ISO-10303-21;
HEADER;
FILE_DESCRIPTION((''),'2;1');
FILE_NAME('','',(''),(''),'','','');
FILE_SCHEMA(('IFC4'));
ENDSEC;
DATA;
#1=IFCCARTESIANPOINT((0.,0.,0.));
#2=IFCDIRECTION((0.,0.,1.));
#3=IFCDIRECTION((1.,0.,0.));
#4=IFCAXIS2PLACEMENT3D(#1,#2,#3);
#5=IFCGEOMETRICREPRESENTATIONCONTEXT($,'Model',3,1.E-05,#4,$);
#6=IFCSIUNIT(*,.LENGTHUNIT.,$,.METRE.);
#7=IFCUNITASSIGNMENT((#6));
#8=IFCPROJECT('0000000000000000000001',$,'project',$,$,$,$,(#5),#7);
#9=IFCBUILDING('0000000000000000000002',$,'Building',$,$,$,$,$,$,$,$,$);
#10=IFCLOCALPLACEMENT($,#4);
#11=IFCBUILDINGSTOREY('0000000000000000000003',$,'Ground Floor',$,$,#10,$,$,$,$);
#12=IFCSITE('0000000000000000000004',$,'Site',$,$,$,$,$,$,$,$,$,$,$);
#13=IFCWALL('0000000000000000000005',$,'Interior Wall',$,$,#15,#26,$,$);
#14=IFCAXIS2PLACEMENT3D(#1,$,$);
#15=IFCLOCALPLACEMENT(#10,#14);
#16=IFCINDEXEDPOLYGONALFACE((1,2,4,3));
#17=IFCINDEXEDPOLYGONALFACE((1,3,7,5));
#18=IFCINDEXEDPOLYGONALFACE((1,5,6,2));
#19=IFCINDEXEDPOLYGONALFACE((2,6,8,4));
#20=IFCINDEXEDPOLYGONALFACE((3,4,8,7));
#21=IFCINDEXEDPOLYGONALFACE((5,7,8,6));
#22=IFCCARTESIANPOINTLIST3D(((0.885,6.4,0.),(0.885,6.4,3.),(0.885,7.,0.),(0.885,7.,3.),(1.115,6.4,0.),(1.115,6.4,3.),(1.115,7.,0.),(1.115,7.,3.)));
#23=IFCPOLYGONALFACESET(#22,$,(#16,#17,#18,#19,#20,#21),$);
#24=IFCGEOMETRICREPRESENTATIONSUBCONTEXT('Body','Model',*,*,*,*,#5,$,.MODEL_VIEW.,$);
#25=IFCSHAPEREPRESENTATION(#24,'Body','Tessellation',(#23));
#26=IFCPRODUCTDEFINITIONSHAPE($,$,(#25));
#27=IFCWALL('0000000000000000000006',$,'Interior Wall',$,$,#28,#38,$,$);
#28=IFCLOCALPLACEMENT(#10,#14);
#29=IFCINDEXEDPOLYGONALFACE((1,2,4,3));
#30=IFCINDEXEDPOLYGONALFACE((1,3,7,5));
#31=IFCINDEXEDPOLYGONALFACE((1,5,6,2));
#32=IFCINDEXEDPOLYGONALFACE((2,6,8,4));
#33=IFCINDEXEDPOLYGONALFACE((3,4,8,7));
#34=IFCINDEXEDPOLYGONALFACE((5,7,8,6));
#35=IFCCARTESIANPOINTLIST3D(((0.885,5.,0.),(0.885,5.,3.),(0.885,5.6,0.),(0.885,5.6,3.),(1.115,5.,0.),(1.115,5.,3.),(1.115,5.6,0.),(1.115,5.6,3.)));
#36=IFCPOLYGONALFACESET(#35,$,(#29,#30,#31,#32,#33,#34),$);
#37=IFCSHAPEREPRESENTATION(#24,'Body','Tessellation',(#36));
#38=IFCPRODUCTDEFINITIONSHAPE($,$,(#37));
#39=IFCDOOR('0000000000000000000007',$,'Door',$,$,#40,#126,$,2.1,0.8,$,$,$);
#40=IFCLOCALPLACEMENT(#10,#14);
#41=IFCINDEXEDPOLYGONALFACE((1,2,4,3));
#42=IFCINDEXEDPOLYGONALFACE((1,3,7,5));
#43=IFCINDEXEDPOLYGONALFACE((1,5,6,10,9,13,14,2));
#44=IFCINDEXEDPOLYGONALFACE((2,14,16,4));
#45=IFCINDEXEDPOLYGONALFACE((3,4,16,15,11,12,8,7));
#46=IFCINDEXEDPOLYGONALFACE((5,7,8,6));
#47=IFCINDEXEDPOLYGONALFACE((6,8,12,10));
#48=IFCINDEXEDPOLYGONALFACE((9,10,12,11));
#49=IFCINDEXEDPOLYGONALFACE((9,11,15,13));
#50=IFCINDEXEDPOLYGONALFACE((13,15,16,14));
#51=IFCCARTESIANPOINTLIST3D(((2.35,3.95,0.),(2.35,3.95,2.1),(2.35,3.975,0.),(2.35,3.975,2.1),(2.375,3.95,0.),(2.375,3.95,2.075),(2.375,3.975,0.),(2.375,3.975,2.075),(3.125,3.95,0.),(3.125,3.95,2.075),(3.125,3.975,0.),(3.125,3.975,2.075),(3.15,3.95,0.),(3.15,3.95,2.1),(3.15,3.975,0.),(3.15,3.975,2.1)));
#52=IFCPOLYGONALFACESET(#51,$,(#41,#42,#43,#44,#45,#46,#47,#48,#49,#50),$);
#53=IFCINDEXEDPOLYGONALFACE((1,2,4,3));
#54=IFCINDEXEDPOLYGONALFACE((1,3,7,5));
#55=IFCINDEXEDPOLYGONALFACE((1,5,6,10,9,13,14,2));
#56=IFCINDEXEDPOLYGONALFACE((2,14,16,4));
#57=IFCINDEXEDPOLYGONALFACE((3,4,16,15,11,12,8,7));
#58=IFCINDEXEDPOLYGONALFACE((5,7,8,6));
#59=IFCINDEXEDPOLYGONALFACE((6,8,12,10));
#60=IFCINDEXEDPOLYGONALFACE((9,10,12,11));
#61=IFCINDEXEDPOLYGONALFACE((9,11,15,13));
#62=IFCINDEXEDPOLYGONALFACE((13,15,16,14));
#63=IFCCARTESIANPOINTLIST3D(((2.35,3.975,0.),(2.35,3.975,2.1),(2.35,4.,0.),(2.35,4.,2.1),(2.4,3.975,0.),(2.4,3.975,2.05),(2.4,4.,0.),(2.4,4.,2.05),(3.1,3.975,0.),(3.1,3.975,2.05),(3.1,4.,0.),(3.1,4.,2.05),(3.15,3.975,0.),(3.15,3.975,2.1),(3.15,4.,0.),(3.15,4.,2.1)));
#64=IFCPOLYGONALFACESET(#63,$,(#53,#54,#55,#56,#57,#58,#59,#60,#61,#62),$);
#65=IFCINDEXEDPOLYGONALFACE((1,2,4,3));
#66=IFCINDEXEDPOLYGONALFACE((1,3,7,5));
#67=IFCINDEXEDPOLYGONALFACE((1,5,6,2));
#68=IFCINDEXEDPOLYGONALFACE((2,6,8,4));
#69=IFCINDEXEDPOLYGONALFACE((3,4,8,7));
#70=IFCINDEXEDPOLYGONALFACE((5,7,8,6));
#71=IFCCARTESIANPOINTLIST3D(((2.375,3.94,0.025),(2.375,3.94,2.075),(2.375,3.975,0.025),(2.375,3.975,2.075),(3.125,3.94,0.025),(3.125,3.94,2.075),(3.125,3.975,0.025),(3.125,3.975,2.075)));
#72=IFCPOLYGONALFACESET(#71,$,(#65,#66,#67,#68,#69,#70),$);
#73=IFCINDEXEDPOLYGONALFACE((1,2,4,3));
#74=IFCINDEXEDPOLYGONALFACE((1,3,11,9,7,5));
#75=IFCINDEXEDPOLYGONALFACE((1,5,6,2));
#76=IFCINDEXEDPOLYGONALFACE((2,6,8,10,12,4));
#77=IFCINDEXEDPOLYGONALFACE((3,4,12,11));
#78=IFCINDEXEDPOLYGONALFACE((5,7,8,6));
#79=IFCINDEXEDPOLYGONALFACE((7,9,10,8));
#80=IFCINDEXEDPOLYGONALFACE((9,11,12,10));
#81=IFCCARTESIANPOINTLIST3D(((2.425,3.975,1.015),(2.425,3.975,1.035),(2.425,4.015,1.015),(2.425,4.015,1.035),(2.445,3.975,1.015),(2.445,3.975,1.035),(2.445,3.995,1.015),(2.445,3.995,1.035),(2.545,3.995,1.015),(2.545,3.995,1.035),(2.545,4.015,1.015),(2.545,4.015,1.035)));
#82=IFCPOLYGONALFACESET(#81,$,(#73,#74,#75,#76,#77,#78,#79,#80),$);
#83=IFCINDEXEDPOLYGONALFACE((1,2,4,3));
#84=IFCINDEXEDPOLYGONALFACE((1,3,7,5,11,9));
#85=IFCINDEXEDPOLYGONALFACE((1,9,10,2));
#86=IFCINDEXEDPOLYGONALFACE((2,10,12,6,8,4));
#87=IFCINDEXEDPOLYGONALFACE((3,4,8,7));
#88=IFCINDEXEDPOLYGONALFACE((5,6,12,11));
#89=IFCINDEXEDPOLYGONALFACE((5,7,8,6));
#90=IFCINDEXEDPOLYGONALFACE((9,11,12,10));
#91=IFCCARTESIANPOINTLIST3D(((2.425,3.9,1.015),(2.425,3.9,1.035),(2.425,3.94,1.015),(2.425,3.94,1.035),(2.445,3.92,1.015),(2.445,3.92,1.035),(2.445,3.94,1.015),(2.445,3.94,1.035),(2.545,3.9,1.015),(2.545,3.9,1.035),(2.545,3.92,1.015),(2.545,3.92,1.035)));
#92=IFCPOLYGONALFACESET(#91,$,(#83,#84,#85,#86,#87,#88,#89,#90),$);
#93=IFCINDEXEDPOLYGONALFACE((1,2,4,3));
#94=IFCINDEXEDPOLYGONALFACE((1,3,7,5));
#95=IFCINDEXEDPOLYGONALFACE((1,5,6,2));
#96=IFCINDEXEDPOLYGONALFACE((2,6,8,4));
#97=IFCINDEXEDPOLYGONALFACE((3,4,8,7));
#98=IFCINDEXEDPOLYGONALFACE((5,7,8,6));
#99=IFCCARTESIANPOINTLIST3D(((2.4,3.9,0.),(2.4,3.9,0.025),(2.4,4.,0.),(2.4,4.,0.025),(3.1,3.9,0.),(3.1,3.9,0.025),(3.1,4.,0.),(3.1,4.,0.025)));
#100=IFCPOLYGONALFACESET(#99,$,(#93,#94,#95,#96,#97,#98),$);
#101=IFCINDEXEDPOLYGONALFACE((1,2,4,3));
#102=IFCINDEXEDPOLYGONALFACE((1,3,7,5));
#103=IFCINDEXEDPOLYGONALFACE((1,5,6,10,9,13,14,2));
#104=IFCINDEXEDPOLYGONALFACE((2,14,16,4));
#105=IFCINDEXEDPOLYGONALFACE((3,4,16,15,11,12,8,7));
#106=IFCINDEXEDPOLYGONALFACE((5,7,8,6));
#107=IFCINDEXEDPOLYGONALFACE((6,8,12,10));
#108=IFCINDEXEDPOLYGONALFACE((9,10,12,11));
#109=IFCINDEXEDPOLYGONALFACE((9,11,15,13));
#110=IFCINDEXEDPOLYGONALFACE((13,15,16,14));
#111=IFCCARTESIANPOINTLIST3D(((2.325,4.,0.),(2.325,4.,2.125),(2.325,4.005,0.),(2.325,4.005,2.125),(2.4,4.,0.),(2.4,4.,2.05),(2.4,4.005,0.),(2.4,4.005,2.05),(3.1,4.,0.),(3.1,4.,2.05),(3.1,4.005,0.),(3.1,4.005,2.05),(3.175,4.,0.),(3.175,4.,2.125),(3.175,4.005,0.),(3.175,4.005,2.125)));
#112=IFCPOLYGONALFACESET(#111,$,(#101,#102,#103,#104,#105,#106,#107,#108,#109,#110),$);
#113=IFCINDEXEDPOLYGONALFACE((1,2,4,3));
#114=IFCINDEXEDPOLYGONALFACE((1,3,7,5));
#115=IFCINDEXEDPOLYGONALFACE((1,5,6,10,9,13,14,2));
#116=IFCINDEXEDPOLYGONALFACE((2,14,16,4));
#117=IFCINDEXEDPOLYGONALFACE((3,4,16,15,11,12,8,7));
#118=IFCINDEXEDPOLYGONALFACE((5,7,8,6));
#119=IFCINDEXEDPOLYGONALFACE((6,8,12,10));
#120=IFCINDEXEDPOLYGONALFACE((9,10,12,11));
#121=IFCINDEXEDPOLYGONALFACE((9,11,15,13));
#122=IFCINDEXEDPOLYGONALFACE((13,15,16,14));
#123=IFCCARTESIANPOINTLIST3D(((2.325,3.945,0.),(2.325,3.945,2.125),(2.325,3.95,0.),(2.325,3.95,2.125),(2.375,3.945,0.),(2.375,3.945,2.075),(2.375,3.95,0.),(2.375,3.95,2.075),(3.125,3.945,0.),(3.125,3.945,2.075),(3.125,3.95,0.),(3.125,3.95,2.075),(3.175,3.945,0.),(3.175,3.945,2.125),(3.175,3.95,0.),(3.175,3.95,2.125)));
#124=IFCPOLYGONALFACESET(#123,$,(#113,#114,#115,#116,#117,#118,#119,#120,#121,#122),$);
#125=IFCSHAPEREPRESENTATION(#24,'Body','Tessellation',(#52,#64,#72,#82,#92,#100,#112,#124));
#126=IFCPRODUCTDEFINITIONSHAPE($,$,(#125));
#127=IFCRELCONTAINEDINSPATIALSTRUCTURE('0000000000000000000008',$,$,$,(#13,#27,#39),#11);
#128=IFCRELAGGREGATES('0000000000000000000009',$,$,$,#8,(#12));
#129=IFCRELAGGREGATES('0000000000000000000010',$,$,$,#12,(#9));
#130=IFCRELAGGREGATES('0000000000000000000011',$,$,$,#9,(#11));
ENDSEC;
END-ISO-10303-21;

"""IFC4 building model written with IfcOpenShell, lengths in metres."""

from ifc_helpers import new_model, si_unit, frame, origin_with_axes, place, context, subcontext, project, spatial, line, indexed_curve, outline, extrude, element, save


model = new_model("IFC4")

# Units and contexts
model_context = context("Model", 3, precision=1e-05, world=origin_with_axes())
body_context = subcontext(model_context, "Body", "Model", "MODEL_VIEW")
ifc_project = project(units=[si_unit("LENGTHUNIT", "METRE")], contexts=[model_context])

# Site, building, storey
site = spatial("IfcSite", under=ifc_project, Name="Site")
building = spatial("IfcBuilding", under=site, Name="Building")
storey_placement = place(None, origin_with_axes())
storey = spatial("IfcBuildingStorey", under=building, at=storey_placement, Name="Ground Floor")

# Walls
for number, where, z_axis, x_axis, name in (
    (1, (1.0, 7.0, 0.0), (0.0, 0.0, 1.0), (0.0, -1.0, 0.0), "Interior Wall"),
    (2, (1.0, 5.6, 0.0), (0.0, 0.0, 1.0), (0.0, -1.0, 0.0), "Interior Wall"),
):
    element("IfcWall", number, at=place(storey_placement, frame(where, z_axis=z_axis, x_axis=x_axis)), inside=storey, Name=name, context=body_context, shape_type="SweptSolid", body=[
        extrude(outline(indexed_curve([(0.0, 0.0), (0.0, 0.23), (0.6, 0.23), (0.6, 0.0), (0.0, 0.0)], self_intersect=False)), frame((0.0, -0.115, 0.0), z_axis=(0.0, 0.0, 1.0), x_axis=(1.0, 0.0, 0.0)), (0.0, 0.0, 1.0), 3.0),
    ])

# Door
door_1_placement = place(storey_placement, frame((3.15, 4.0, 0.0), z_axis=(0.0, 0.0, 1.0), x_axis=(-1.0, 0.0, 0.0)))
element("IfcDoor", 3, at=door_1_placement, inside=storey, Name="Door", OverallHeight=2.1, OverallWidth=0.8, context=body_context, shape_type="SweptSolid", body=[
    extrude(outline(indexed_curve([(0.0, 0.0), (0.0, 2.1), (0.8, 2.1), (0.8, 0.0), (0.775, 0.0), (0.775, 2.075), (0.025, 2.075), (0.025, 0.0)], segments=[line(1, 2, 3, 4, 5, 6, 7, 8, 1)])), frame((0.0, 0.025, 0.0), z_axis=(0.0, -1.0, 0.0), x_axis=(1.0, 0.0, 0.0)), (0.0, 0.0, -1.0), 0.025),
    extrude(outline(indexed_curve([(0.0, 0.0), (0.0, 2.1), (0.8, 2.1), (0.8, 0.0), (0.75, 0.0), (0.75, 2.05), (0.05, 2.05), (0.05, 0.0)], segments=[line(1, 2, 3, 4, 5, 6, 7, 8, 1)])), frame((0.0, 0.0, 0.0), z_axis=(0.0, -1.0, 0.0), x_axis=(1.0, 0.0, 0.0)), (0.0, 0.0, -1.0), 0.025),
    extrude(outline(indexed_curve([(0.0, 0.0), (0.75, 0.0), (0.75, 0.035), (0.0, 0.035)], segments=[line(1, 2, 3, 4, 1)])), frame((0.025, 0.025, 0.025), z_axis=(0.0, 0.0, 1.0), x_axis=(1.0, 0.0, 0.0)), (0.0, 0.0, 1.0), 2.05),
    extrude(outline(indexed_curve([(0.0, 0.0), (0.0, -0.04), (-0.12, -0.04), (-0.12, -0.02), (-0.02, -0.02), (-0.02, 0.0)], segments=[line(1, 2, 3, 4, 5, 6, 1)])), frame((0.725, 0.025, 1.015), z_axis=(0.0, 0.0, 1.0), x_axis=(1.0, 0.0, 0.0)), (0.0, 0.0, 1.0), 0.02),
    extrude(outline(indexed_curve([(0.0, 0.0), (0.0, 0.04), (-0.12, 0.04), (-0.12, 0.02), (-0.02, 0.02), (-0.02, 0.0)], segments=[line(1, 2, 3, 4, 5, 6, 1)])), frame((0.725, 0.06, 1.015), z_axis=(0.0, 0.0, 1.0), x_axis=(1.0, 0.0, 0.0)), (0.0, 0.0, 1.0), 0.02),
    extrude(outline(indexed_curve([(0.0, 0.0), (0.7, 0.0), (0.7, 0.1), (0.0, 0.1)], segments=[line(1, 2, 3, 4, 1)])), frame((0.05, 0.0, 0.0), z_axis=(0.0, 0.0, 1.0), x_axis=(1.0, 0.0, 0.0)), (0.0, 0.0, 1.0), 0.025),
    extrude(outline(indexed_curve([(0.0, 0.0), (0.0, 2.125), (0.85, 2.125), (0.85, 0.0), (0.775, 0.0), (0.775, 2.05), (0.075, 2.05), (0.075, 0.0)], segments=[line(1, 2, 3, 4, 5, 6, 7, 8, 1)])), frame((-0.025, -0.005, 0.0), z_axis=(0.0, -1.0, 0.0), x_axis=(1.0, 0.0, 0.0)), (0.0, 0.0, -1.0), 0.005),
    extrude(outline(indexed_curve([(0.0, 0.0), (0.0, 2.125), (0.85, 2.125), (0.85, 0.0), (0.8, 0.0), (0.8, 2.075), (0.05, 2.075), (0.05, 0.0)], segments=[line(1, 2, 3, 4, 5, 6, 7, 8, 1)])), frame((-0.025, 0.05, 0.0), z_axis=(0.0, -1.0, 0.0), x_axis=(1.0, 0.0, 0.0)), (0.0, 0.0, -1.0), 0.005),
])

save(model, "model.ifc")
